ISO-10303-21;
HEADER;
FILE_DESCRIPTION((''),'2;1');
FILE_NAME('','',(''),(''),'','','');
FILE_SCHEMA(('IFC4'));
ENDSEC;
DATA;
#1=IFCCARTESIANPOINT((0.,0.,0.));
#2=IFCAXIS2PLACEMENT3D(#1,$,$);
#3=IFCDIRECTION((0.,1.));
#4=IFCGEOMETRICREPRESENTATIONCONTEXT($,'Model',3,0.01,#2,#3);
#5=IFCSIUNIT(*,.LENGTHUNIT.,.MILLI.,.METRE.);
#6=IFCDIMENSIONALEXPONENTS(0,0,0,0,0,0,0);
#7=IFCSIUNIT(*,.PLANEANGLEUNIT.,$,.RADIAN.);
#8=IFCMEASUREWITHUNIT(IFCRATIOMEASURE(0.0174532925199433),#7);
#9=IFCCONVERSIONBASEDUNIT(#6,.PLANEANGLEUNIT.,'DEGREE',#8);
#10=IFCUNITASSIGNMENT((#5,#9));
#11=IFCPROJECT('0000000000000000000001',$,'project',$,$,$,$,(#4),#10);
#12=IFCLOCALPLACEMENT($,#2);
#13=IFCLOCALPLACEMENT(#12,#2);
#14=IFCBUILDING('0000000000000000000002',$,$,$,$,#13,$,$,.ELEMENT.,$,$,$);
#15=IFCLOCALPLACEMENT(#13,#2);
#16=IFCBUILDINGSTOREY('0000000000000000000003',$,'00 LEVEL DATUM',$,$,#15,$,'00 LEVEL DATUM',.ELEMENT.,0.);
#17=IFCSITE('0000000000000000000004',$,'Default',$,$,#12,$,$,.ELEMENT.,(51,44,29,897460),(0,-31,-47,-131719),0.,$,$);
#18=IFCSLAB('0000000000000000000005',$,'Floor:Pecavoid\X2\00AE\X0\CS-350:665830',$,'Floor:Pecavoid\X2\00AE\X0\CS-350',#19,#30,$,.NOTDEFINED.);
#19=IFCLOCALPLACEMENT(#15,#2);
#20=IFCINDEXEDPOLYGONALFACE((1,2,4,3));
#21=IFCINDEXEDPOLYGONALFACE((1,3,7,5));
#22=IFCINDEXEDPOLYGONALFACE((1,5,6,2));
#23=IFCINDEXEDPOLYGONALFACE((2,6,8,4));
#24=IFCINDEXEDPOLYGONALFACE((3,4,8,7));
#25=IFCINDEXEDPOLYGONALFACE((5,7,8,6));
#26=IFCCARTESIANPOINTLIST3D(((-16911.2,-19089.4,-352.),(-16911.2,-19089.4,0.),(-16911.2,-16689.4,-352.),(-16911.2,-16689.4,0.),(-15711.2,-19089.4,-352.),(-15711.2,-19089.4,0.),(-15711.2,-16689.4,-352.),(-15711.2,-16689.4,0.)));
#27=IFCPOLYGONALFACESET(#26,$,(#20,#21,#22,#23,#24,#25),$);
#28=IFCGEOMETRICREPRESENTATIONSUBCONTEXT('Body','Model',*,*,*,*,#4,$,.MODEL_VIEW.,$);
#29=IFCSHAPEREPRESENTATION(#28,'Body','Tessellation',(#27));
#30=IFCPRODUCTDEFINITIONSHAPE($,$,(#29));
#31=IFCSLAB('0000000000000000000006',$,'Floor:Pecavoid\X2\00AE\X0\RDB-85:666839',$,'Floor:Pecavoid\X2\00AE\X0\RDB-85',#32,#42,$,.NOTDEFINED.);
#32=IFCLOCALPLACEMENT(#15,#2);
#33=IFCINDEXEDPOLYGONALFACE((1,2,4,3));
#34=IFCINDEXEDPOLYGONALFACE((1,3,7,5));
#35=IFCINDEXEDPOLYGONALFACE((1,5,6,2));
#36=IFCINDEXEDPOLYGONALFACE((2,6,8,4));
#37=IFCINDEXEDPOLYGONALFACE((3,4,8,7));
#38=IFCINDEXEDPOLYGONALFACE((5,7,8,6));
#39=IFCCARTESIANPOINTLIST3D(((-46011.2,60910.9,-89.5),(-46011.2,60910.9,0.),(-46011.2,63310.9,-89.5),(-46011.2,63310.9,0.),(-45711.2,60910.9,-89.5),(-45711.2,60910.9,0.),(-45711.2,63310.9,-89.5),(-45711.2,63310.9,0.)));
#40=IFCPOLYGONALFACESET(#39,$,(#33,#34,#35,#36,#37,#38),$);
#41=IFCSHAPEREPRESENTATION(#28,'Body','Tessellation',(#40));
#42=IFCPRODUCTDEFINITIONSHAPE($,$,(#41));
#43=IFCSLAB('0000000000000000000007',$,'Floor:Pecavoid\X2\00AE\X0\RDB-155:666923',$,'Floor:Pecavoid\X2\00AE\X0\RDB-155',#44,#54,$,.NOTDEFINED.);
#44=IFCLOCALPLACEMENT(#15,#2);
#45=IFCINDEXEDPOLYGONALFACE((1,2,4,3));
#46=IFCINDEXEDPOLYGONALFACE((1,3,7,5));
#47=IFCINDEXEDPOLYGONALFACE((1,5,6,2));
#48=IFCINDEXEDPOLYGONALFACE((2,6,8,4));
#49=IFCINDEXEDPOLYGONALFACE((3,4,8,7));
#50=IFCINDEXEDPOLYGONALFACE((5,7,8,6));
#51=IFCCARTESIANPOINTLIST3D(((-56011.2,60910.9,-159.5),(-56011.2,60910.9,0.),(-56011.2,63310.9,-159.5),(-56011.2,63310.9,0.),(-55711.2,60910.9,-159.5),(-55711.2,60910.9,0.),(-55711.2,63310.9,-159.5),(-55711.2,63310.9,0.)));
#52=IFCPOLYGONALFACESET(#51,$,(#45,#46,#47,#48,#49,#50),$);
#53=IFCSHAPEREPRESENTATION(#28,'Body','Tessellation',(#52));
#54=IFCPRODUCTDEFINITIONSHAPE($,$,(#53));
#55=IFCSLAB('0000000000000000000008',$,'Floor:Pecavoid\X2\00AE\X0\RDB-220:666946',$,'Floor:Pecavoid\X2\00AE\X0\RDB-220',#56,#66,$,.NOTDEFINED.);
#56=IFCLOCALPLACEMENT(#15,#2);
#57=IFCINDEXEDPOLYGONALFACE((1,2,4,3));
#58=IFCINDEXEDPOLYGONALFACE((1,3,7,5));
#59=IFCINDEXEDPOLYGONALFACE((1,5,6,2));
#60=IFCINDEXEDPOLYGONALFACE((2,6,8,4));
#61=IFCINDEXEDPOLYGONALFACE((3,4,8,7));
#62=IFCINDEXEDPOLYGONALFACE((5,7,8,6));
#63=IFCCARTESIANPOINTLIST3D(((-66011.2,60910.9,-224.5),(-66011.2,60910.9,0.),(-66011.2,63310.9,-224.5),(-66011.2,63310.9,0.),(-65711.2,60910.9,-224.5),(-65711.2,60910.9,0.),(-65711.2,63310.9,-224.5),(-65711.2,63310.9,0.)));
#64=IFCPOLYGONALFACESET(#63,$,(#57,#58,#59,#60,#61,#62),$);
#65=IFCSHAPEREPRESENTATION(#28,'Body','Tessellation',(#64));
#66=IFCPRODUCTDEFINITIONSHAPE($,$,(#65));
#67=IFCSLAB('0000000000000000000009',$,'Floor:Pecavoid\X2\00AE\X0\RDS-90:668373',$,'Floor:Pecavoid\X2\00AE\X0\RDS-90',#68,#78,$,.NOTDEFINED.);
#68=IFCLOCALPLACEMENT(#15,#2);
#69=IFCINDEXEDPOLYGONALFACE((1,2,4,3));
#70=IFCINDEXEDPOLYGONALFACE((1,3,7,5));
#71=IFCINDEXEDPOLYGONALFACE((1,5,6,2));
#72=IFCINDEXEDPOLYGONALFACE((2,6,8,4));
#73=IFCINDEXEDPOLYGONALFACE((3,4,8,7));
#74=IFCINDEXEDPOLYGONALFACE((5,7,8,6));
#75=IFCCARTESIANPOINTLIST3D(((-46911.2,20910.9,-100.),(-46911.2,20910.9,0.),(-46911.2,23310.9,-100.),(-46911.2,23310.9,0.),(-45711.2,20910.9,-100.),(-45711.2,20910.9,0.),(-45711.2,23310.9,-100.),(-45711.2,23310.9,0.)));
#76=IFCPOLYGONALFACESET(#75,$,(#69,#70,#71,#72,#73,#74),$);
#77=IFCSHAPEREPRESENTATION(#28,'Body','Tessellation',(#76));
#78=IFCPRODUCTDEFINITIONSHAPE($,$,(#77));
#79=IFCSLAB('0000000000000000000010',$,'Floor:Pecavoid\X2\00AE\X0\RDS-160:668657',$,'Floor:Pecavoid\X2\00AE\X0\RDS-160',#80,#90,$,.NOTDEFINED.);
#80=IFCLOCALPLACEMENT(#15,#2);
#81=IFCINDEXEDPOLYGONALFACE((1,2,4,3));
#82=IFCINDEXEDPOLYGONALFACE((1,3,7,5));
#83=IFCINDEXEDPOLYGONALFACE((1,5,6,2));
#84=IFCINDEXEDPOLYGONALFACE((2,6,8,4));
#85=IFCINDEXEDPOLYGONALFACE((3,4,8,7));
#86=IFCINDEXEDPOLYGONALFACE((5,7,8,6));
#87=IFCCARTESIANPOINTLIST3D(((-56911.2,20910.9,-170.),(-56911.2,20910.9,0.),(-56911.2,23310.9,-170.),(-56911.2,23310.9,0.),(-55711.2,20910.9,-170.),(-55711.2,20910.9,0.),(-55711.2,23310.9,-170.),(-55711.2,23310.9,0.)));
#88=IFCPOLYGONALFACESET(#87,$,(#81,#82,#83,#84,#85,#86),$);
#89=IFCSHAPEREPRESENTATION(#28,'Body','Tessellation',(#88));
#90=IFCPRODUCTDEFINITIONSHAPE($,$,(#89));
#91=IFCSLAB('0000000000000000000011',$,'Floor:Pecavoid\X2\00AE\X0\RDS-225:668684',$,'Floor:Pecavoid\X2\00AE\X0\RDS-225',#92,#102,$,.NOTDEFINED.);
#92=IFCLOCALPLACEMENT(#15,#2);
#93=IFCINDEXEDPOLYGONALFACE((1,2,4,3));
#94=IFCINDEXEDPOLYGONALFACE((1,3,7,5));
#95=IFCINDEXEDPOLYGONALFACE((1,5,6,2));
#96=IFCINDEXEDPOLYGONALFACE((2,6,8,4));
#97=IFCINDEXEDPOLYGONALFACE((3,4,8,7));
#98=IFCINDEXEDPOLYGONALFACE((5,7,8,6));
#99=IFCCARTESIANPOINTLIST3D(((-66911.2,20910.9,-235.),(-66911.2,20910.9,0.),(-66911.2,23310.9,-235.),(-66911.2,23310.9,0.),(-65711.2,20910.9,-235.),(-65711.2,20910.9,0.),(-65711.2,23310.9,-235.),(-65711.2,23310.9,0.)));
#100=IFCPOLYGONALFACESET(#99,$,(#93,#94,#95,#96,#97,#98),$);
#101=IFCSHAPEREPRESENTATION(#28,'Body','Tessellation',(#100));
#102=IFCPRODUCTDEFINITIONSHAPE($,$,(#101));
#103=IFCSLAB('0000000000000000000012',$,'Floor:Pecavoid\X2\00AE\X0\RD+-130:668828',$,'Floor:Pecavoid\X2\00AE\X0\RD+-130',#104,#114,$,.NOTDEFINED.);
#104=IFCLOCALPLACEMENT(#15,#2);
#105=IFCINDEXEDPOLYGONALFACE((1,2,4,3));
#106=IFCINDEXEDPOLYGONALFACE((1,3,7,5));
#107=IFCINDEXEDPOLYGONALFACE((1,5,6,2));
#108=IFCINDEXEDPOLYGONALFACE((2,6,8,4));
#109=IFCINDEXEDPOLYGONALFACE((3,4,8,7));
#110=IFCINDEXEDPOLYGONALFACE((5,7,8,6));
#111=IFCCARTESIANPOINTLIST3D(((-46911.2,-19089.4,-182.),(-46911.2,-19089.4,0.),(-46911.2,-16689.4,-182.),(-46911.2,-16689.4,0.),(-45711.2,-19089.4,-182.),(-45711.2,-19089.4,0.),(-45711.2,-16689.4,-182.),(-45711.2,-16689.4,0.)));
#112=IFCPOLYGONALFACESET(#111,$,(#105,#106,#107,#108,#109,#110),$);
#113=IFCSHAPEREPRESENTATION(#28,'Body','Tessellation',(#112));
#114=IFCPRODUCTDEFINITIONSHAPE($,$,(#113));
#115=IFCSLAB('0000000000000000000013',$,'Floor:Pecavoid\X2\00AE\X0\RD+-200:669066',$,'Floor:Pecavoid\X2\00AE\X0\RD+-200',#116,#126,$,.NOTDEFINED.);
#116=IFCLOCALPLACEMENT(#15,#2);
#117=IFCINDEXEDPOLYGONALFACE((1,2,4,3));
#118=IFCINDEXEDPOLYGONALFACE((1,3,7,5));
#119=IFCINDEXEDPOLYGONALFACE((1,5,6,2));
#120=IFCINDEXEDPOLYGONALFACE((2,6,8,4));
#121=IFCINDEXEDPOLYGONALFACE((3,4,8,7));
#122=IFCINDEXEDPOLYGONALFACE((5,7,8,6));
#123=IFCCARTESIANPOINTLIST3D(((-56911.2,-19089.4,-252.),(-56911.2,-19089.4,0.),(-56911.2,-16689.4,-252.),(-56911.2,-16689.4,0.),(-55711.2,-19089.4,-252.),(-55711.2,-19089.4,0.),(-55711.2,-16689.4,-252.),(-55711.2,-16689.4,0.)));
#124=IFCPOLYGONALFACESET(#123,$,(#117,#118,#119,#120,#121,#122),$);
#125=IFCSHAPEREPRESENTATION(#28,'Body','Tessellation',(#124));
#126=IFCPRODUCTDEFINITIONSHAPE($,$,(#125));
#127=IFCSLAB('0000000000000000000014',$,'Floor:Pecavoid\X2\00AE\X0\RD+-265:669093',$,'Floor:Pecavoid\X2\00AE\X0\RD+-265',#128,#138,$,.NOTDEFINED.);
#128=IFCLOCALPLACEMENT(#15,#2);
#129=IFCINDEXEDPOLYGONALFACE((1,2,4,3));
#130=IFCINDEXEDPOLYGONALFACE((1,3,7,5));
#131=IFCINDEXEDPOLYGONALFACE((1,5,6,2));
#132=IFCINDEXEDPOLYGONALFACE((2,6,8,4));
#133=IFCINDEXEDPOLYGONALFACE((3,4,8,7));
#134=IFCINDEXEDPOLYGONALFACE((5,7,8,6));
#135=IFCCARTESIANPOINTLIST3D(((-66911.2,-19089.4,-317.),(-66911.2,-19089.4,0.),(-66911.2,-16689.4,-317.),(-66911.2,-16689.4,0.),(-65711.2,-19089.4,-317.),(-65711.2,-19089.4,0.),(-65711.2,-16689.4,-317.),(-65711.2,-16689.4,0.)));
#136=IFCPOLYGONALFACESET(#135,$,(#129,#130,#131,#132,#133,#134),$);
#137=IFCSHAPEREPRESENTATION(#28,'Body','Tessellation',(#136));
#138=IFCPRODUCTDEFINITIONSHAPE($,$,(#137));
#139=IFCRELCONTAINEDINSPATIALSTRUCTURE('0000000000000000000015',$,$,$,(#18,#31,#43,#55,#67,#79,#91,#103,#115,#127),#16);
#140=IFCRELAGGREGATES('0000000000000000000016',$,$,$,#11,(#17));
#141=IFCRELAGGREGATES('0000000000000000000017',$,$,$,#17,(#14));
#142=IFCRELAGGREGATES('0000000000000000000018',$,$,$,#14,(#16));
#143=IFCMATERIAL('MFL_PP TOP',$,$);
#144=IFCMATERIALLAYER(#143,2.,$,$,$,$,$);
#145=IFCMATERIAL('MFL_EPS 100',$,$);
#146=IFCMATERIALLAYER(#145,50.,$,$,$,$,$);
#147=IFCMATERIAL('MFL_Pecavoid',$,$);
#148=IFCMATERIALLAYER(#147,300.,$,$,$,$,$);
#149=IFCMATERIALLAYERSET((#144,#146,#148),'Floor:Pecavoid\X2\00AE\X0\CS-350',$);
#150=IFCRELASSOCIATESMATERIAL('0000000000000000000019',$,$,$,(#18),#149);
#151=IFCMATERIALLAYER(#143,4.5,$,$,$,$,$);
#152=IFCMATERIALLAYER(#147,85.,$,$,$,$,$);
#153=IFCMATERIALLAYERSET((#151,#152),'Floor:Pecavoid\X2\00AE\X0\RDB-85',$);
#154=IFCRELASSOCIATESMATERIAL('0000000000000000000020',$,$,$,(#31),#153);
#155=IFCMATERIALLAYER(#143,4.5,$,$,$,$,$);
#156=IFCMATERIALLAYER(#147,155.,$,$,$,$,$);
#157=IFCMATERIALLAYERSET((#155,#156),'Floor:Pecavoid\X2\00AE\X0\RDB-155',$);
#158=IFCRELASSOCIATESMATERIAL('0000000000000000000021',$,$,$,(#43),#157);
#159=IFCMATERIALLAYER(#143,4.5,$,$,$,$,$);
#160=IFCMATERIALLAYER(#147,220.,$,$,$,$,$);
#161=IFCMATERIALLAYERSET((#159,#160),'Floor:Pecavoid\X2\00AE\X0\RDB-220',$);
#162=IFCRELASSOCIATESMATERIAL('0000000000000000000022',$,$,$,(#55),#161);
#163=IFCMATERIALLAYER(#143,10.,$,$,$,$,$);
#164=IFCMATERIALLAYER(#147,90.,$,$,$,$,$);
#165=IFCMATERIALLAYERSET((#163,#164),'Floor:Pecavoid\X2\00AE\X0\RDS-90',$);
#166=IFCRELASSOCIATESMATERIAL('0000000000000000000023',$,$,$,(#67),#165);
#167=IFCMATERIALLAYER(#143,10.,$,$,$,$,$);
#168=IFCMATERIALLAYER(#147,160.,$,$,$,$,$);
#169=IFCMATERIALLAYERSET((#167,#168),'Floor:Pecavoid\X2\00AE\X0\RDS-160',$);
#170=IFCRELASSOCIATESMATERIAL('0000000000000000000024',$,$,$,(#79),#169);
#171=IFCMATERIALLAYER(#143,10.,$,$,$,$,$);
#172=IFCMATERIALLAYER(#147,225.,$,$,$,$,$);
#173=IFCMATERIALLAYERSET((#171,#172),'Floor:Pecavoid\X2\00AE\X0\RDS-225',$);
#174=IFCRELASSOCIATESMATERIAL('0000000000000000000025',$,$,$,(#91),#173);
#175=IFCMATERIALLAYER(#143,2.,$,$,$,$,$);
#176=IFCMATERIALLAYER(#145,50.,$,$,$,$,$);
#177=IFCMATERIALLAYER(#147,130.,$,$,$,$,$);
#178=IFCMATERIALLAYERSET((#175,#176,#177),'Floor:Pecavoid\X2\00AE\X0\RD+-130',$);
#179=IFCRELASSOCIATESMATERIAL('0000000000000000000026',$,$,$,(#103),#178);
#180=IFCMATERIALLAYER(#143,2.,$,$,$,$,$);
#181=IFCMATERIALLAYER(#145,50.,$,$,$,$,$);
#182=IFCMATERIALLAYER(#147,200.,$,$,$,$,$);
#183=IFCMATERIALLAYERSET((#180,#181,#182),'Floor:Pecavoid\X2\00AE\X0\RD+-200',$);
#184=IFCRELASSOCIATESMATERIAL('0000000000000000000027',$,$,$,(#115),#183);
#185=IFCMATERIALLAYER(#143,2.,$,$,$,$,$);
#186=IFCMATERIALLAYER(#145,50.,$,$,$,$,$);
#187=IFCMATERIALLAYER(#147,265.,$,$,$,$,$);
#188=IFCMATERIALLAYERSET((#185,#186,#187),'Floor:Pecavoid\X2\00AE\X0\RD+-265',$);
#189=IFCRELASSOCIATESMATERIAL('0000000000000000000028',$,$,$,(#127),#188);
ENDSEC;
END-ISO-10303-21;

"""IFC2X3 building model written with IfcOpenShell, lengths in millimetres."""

from ifc_helpers import new_model, entity, si_unit, converted_unit, direction, frame, frame_2d, origin, origin_2d_with_axis, place, context, subcontext, project, spatial, rectangle, extrude, material, layer, layer_set, layer_usage, element, save


model = new_model("IFC2X3")

# Units and contexts
model_context = context("Model", 3, precision=0.01, world=origin(), true_north=direction((0.0, 1.0)))
body_context = subcontext(model_context, "Body", "Model", "MODEL_VIEW")
ifc_project = project(units=[si_unit("LENGTHUNIT", "METRE", prefix="MILLI"), converted_unit("PLANEANGLEUNIT", "DEGREE", entity("IfcRatioMeasure", 0.0174532925199433), si_unit("PLANEANGLEUNIT", "RADIAN"), dimensions=[0, 0, 0, 0, 0, 0, 0])], contexts=[model_context])

# Site, building, storey
site_placement = place(None, origin())
site = spatial("IfcSite", under=ifc_project, at=site_placement, Name="Default", CompositionType="ELEMENT", RefLatitude=(51, 44, 29, 897460), RefLongitude=(0, -31, -47, -131719), RefElevation=0.0)
building_placement = place(site_placement, origin())
building = spatial("IfcBuilding", under=site, at=building_placement, CompositionType="ELEMENT")
storey_placement = place(building_placement, origin())
storey = spatial("IfcBuildingStorey", under=building, at=storey_placement, Name="00 LEVEL DATUM", LongName="00 LEVEL DATUM", CompositionType="ELEMENT", Elevation=0.0)

# Slabs
ifc_material_1 = material(Name="MFL_PP TOP")
ifc_layer_1 = layer(ifc_material_1, 2.0)
ifc_material_2 = material(Name="MFL_EPS 100")
ifc_layer_2 = layer(ifc_material_2, 50.0)
ifc_material_3 = material(Name="MFL_Pecavoid")
ifc_layer_3 = layer(ifc_material_3, 300.0)
ifc_layer_set_1 = layer_set([ifc_layer_1, ifc_layer_2, ifc_layer_3], Name="Floor:Pecavoid®CS-350")
ifc_layer_usage_1 = layer_usage(ifc_layer_set_1, "AXIS3", "POSITIVE", 0.0)
slab_1_placement = place(storey_placement, origin())
element("IfcSlab", 1, at=slab_1_placement, inside=storey, material=ifc_layer_usage_1, Name="Floor:Pecavoid®CS-350:665830", ObjectType="Floor:Pecavoid®CS-350", PredefinedType="NOTDEFINED", context=body_context, shape_type="SweptSolid", body=[
    extrude(rectangle(XDim=2400.0, YDim=1200.0, at=frame_2d((0.0, 0.0), x_axis=(1.0, 0.0))), frame((-16311.2, -17889.4, 0.0), z_axis=(0.0, 0.0, -1.0), x_axis=(0.0, 1.0, 0.0)), (0.0, 0.0, 1.0), 352.0),
])
ifc_layer_4 = layer(ifc_material_1, 4.5)
ifc_layer_5 = layer(ifc_material_3, 85.0)
ifc_layer_set_2 = layer_set([ifc_layer_4, ifc_layer_5], Name="Floor:Pecavoid®RDB-85")
ifc_layer_usage_2 = layer_usage(ifc_layer_set_2, "AXIS3", "POSITIVE", 0.0)
slab_2_placement = place(storey_placement, origin())
element("IfcSlab", 2, at=slab_2_placement, inside=storey, material=ifc_layer_usage_2, Name="Floor:Pecavoid®RDB-85:666839", ObjectType="Floor:Pecavoid®RDB-85", PredefinedType="NOTDEFINED", context=body_context, shape_type="SweptSolid", body=[
    extrude(rectangle(XDim=2400.0, YDim=300.0, at=origin_2d_with_axis()), frame((-45861.2, 62110.9, 0.0), z_axis=(0.0, 0.0, -1.0), x_axis=(0.0, 1.0, 0.0)), (0.0, 0.0, 1.0), 89.5),
])
ifc_layer_6 = layer(ifc_material_1, 4.5)
ifc_layer_7 = layer(ifc_material_3, 155.0)
ifc_layer_set_3 = layer_set([ifc_layer_6, ifc_layer_7], Name="Floor:Pecavoid®RDB-155")
ifc_layer_usage_3 = layer_usage(ifc_layer_set_3, "AXIS3", "POSITIVE", 0.0)
slab_3_placement = place(storey_placement, origin())
element("IfcSlab", 3, at=slab_3_placement, inside=storey, material=ifc_layer_usage_3, Name="Floor:Pecavoid®RDB-155:666923", ObjectType="Floor:Pecavoid®RDB-155", PredefinedType="NOTDEFINED", context=body_context, shape_type="SweptSolid", body=[
    extrude(rectangle(XDim=2400.0, YDim=300.0, at=origin_2d_with_axis()), frame((-55861.2, 62110.9, 0.0), z_axis=(0.0, 0.0, -1.0), x_axis=(0.0, 1.0, 0.0)), (0.0, 0.0, 1.0), 159.5),
])
ifc_layer_8 = layer(ifc_material_1, 4.5)
ifc_layer_9 = layer(ifc_material_3, 220.0)
ifc_layer_set_4 = layer_set([ifc_layer_8, ifc_layer_9], Name="Floor:Pecavoid®RDB-220")
ifc_layer_usage_4 = layer_usage(ifc_layer_set_4, "AXIS3", "POSITIVE", 0.0)
slab_4_placement = place(storey_placement, origin())
element("IfcSlab", 4, at=slab_4_placement, inside=storey, material=ifc_layer_usage_4, Name="Floor:Pecavoid®RDB-220:666946", ObjectType="Floor:Pecavoid®RDB-220", PredefinedType="NOTDEFINED", context=body_context, shape_type="SweptSolid", body=[
    extrude(rectangle(XDim=2400.0, YDim=300.0, at=origin_2d_with_axis()), frame((-65861.2, 62110.9, 0.0), z_axis=(0.0, 0.0, -1.0), x_axis=(0.0, 1.0, 0.0)), (0.0, 0.0, 1.0), 224.5),
])
ifc_layer_10 = layer(ifc_material_1, 10.0)
ifc_layer_11 = layer(ifc_material_3, 90.0)
ifc_layer_set_5 = layer_set([ifc_layer_10, ifc_layer_11], Name="Floor:Pecavoid®RDS-90")
ifc_layer_usage_5 = layer_usage(ifc_layer_set_5, "AXIS3", "POSITIVE", 0.0)
slab_5_placement = place(storey_placement, origin())
element("IfcSlab", 5, at=slab_5_placement, inside=storey, material=ifc_layer_usage_5, Name="Floor:Pecavoid®RDS-90:668373", ObjectType="Floor:Pecavoid®RDS-90", PredefinedType="NOTDEFINED", context=body_context, shape_type="SweptSolid", body=[
    extrude(rectangle(XDim=2400.0, YDim=1200.0, at=origin_2d_with_axis()), frame((-46311.2, 22110.9, 0.0), z_axis=(0.0, 0.0, -1.0), x_axis=(0.0, 1.0, 0.0)), (0.0, 0.0, 1.0), 100.0),
])
ifc_layer_12 = layer(ifc_material_1, 10.0)
ifc_layer_13 = layer(ifc_material_3, 160.0)
ifc_layer_set_6 = layer_set([ifc_layer_12, ifc_layer_13], Name="Floor:Pecavoid®RDS-160")
ifc_layer_usage_6 = layer_usage(ifc_layer_set_6, "AXIS3", "POSITIVE", 0.0)
slab_6_placement = place(storey_placement, origin())
element("IfcSlab", 6, at=slab_6_placement, inside=storey, material=ifc_layer_usage_6, Name="Floor:Pecavoid®RDS-160:668657", ObjectType="Floor:Pecavoid®RDS-160", PredefinedType="NOTDEFINED", context=body_context, shape_type="SweptSolid", body=[
    extrude(rectangle(XDim=2400.0, YDim=1200.0, at=origin_2d_with_axis()), frame((-56311.2, 22110.9, 0.0), z_axis=(0.0, 0.0, -1.0), x_axis=(0.0, 1.0, 0.0)), (0.0, 0.0, 1.0), 170.0),
])
ifc_layer_14 = layer(ifc_material_1, 10.0)
ifc_layer_15 = layer(ifc_material_3, 225.0)
ifc_layer_set_7 = layer_set([ifc_layer_14, ifc_layer_15], Name="Floor:Pecavoid®RDS-225")
ifc_layer_usage_7 = layer_usage(ifc_layer_set_7, "AXIS3", "POSITIVE", 0.0)
slab_7_placement = place(storey_placement, origin())
element("IfcSlab", 7, at=slab_7_placement, inside=storey, material=ifc_layer_usage_7, Name="Floor:Pecavoid®RDS-225:668684", ObjectType="Floor:Pecavoid®RDS-225", PredefinedType="NOTDEFINED", context=body_context, shape_type="SweptSolid", body=[
    extrude(rectangle(XDim=2400.0, YDim=1200.0, at=origin_2d_with_axis()), frame((-66311.2, 22110.9, 0.0), z_axis=(0.0, 0.0, -1.0), x_axis=(0.0, 1.0, 0.0)), (0.0, 0.0, 1.0), 235.0),
])
ifc_layer_16 = layer(ifc_material_1, 2.0)
ifc_layer_17 = layer(ifc_material_2, 50.0)
ifc_layer_18 = layer(ifc_material_3, 130.0)
ifc_layer_set_8 = layer_set([ifc_layer_16, ifc_layer_17, ifc_layer_18], Name="Floor:Pecavoid®RD+-130")
ifc_layer_usage_8 = layer_usage(ifc_layer_set_8, "AXIS3", "POSITIVE", 0.0)
slab_8_placement = place(storey_placement, origin())
element("IfcSlab", 8, at=slab_8_placement, inside=storey, material=ifc_layer_usage_8, Name="Floor:Pecavoid®RD+-130:668828", ObjectType="Floor:Pecavoid®RD+-130", PredefinedType="NOTDEFINED", context=body_context, shape_type="SweptSolid", body=[
    extrude(rectangle(XDim=2400.0, YDim=1200.0, at=origin_2d_with_axis()), frame((-46311.2, -17889.4, 0.0), z_axis=(0.0, 0.0, -1.0), x_axis=(0.0, 1.0, 0.0)), (0.0, 0.0, 1.0), 182.0),
])
ifc_layer_19 = layer(ifc_material_1, 2.0)
ifc_layer_20 = layer(ifc_material_2, 50.0)
ifc_layer_21 = layer(ifc_material_3, 200.0)
ifc_layer_set_9 = layer_set([ifc_layer_19, ifc_layer_20, ifc_layer_21], Name="Floor:Pecavoid®RD+-200")
ifc_layer_usage_9 = layer_usage(ifc_layer_set_9, "AXIS3", "POSITIVE", 0.0)
slab_9_placement = place(storey_placement, origin())
element("IfcSlab", 9, at=slab_9_placement, inside=storey, material=ifc_layer_usage_9, Name="Floor:Pecavoid®RD+-200:669066", ObjectType="Floor:Pecavoid®RD+-200", PredefinedType="NOTDEFINED", context=body_context, shape_type="SweptSolid", body=[
    extrude(rectangle(XDim=2400.0, YDim=1200.0, at=origin_2d_with_axis()), frame((-56311.2, -17889.4, 0.0), z_axis=(0.0, 0.0, -1.0), x_axis=(0.0, 1.0, 0.0)), (0.0, 0.0, 1.0), 252.0),
])
ifc_layer_22 = layer(ifc_material_1, 2.0)
ifc_layer_23 = layer(ifc_material_2, 50.0)
ifc_layer_24 = layer(ifc_material_3, 265.0)
ifc_layer_set_10 = layer_set([ifc_layer_22, ifc_layer_23, ifc_layer_24], Name="Floor:Pecavoid®RD+-265")
ifc_layer_usage_10 = layer_usage(ifc_layer_set_10, "AXIS3", "POSITIVE", 0.0)
slab_10_placement = place(storey_placement, origin())
element("IfcSlab", 10, at=slab_10_placement, inside=storey, material=ifc_layer_usage_10, Name="Floor:Pecavoid®RD+-265:669093", ObjectType="Floor:Pecavoid®RD+-265", PredefinedType="NOTDEFINED", context=body_context, shape_type="SweptSolid", body=[
    extrude(rectangle(XDim=2400.0, YDim=1200.0, at=origin_2d_with_axis()), frame((-66311.2, -17889.4, 0.0), z_axis=(0.0, 0.0, -1.0), x_axis=(0.0, 1.0, 0.0)), (0.0, 0.0, 1.0), 317.0),
])

save(model, "model.ifc")
